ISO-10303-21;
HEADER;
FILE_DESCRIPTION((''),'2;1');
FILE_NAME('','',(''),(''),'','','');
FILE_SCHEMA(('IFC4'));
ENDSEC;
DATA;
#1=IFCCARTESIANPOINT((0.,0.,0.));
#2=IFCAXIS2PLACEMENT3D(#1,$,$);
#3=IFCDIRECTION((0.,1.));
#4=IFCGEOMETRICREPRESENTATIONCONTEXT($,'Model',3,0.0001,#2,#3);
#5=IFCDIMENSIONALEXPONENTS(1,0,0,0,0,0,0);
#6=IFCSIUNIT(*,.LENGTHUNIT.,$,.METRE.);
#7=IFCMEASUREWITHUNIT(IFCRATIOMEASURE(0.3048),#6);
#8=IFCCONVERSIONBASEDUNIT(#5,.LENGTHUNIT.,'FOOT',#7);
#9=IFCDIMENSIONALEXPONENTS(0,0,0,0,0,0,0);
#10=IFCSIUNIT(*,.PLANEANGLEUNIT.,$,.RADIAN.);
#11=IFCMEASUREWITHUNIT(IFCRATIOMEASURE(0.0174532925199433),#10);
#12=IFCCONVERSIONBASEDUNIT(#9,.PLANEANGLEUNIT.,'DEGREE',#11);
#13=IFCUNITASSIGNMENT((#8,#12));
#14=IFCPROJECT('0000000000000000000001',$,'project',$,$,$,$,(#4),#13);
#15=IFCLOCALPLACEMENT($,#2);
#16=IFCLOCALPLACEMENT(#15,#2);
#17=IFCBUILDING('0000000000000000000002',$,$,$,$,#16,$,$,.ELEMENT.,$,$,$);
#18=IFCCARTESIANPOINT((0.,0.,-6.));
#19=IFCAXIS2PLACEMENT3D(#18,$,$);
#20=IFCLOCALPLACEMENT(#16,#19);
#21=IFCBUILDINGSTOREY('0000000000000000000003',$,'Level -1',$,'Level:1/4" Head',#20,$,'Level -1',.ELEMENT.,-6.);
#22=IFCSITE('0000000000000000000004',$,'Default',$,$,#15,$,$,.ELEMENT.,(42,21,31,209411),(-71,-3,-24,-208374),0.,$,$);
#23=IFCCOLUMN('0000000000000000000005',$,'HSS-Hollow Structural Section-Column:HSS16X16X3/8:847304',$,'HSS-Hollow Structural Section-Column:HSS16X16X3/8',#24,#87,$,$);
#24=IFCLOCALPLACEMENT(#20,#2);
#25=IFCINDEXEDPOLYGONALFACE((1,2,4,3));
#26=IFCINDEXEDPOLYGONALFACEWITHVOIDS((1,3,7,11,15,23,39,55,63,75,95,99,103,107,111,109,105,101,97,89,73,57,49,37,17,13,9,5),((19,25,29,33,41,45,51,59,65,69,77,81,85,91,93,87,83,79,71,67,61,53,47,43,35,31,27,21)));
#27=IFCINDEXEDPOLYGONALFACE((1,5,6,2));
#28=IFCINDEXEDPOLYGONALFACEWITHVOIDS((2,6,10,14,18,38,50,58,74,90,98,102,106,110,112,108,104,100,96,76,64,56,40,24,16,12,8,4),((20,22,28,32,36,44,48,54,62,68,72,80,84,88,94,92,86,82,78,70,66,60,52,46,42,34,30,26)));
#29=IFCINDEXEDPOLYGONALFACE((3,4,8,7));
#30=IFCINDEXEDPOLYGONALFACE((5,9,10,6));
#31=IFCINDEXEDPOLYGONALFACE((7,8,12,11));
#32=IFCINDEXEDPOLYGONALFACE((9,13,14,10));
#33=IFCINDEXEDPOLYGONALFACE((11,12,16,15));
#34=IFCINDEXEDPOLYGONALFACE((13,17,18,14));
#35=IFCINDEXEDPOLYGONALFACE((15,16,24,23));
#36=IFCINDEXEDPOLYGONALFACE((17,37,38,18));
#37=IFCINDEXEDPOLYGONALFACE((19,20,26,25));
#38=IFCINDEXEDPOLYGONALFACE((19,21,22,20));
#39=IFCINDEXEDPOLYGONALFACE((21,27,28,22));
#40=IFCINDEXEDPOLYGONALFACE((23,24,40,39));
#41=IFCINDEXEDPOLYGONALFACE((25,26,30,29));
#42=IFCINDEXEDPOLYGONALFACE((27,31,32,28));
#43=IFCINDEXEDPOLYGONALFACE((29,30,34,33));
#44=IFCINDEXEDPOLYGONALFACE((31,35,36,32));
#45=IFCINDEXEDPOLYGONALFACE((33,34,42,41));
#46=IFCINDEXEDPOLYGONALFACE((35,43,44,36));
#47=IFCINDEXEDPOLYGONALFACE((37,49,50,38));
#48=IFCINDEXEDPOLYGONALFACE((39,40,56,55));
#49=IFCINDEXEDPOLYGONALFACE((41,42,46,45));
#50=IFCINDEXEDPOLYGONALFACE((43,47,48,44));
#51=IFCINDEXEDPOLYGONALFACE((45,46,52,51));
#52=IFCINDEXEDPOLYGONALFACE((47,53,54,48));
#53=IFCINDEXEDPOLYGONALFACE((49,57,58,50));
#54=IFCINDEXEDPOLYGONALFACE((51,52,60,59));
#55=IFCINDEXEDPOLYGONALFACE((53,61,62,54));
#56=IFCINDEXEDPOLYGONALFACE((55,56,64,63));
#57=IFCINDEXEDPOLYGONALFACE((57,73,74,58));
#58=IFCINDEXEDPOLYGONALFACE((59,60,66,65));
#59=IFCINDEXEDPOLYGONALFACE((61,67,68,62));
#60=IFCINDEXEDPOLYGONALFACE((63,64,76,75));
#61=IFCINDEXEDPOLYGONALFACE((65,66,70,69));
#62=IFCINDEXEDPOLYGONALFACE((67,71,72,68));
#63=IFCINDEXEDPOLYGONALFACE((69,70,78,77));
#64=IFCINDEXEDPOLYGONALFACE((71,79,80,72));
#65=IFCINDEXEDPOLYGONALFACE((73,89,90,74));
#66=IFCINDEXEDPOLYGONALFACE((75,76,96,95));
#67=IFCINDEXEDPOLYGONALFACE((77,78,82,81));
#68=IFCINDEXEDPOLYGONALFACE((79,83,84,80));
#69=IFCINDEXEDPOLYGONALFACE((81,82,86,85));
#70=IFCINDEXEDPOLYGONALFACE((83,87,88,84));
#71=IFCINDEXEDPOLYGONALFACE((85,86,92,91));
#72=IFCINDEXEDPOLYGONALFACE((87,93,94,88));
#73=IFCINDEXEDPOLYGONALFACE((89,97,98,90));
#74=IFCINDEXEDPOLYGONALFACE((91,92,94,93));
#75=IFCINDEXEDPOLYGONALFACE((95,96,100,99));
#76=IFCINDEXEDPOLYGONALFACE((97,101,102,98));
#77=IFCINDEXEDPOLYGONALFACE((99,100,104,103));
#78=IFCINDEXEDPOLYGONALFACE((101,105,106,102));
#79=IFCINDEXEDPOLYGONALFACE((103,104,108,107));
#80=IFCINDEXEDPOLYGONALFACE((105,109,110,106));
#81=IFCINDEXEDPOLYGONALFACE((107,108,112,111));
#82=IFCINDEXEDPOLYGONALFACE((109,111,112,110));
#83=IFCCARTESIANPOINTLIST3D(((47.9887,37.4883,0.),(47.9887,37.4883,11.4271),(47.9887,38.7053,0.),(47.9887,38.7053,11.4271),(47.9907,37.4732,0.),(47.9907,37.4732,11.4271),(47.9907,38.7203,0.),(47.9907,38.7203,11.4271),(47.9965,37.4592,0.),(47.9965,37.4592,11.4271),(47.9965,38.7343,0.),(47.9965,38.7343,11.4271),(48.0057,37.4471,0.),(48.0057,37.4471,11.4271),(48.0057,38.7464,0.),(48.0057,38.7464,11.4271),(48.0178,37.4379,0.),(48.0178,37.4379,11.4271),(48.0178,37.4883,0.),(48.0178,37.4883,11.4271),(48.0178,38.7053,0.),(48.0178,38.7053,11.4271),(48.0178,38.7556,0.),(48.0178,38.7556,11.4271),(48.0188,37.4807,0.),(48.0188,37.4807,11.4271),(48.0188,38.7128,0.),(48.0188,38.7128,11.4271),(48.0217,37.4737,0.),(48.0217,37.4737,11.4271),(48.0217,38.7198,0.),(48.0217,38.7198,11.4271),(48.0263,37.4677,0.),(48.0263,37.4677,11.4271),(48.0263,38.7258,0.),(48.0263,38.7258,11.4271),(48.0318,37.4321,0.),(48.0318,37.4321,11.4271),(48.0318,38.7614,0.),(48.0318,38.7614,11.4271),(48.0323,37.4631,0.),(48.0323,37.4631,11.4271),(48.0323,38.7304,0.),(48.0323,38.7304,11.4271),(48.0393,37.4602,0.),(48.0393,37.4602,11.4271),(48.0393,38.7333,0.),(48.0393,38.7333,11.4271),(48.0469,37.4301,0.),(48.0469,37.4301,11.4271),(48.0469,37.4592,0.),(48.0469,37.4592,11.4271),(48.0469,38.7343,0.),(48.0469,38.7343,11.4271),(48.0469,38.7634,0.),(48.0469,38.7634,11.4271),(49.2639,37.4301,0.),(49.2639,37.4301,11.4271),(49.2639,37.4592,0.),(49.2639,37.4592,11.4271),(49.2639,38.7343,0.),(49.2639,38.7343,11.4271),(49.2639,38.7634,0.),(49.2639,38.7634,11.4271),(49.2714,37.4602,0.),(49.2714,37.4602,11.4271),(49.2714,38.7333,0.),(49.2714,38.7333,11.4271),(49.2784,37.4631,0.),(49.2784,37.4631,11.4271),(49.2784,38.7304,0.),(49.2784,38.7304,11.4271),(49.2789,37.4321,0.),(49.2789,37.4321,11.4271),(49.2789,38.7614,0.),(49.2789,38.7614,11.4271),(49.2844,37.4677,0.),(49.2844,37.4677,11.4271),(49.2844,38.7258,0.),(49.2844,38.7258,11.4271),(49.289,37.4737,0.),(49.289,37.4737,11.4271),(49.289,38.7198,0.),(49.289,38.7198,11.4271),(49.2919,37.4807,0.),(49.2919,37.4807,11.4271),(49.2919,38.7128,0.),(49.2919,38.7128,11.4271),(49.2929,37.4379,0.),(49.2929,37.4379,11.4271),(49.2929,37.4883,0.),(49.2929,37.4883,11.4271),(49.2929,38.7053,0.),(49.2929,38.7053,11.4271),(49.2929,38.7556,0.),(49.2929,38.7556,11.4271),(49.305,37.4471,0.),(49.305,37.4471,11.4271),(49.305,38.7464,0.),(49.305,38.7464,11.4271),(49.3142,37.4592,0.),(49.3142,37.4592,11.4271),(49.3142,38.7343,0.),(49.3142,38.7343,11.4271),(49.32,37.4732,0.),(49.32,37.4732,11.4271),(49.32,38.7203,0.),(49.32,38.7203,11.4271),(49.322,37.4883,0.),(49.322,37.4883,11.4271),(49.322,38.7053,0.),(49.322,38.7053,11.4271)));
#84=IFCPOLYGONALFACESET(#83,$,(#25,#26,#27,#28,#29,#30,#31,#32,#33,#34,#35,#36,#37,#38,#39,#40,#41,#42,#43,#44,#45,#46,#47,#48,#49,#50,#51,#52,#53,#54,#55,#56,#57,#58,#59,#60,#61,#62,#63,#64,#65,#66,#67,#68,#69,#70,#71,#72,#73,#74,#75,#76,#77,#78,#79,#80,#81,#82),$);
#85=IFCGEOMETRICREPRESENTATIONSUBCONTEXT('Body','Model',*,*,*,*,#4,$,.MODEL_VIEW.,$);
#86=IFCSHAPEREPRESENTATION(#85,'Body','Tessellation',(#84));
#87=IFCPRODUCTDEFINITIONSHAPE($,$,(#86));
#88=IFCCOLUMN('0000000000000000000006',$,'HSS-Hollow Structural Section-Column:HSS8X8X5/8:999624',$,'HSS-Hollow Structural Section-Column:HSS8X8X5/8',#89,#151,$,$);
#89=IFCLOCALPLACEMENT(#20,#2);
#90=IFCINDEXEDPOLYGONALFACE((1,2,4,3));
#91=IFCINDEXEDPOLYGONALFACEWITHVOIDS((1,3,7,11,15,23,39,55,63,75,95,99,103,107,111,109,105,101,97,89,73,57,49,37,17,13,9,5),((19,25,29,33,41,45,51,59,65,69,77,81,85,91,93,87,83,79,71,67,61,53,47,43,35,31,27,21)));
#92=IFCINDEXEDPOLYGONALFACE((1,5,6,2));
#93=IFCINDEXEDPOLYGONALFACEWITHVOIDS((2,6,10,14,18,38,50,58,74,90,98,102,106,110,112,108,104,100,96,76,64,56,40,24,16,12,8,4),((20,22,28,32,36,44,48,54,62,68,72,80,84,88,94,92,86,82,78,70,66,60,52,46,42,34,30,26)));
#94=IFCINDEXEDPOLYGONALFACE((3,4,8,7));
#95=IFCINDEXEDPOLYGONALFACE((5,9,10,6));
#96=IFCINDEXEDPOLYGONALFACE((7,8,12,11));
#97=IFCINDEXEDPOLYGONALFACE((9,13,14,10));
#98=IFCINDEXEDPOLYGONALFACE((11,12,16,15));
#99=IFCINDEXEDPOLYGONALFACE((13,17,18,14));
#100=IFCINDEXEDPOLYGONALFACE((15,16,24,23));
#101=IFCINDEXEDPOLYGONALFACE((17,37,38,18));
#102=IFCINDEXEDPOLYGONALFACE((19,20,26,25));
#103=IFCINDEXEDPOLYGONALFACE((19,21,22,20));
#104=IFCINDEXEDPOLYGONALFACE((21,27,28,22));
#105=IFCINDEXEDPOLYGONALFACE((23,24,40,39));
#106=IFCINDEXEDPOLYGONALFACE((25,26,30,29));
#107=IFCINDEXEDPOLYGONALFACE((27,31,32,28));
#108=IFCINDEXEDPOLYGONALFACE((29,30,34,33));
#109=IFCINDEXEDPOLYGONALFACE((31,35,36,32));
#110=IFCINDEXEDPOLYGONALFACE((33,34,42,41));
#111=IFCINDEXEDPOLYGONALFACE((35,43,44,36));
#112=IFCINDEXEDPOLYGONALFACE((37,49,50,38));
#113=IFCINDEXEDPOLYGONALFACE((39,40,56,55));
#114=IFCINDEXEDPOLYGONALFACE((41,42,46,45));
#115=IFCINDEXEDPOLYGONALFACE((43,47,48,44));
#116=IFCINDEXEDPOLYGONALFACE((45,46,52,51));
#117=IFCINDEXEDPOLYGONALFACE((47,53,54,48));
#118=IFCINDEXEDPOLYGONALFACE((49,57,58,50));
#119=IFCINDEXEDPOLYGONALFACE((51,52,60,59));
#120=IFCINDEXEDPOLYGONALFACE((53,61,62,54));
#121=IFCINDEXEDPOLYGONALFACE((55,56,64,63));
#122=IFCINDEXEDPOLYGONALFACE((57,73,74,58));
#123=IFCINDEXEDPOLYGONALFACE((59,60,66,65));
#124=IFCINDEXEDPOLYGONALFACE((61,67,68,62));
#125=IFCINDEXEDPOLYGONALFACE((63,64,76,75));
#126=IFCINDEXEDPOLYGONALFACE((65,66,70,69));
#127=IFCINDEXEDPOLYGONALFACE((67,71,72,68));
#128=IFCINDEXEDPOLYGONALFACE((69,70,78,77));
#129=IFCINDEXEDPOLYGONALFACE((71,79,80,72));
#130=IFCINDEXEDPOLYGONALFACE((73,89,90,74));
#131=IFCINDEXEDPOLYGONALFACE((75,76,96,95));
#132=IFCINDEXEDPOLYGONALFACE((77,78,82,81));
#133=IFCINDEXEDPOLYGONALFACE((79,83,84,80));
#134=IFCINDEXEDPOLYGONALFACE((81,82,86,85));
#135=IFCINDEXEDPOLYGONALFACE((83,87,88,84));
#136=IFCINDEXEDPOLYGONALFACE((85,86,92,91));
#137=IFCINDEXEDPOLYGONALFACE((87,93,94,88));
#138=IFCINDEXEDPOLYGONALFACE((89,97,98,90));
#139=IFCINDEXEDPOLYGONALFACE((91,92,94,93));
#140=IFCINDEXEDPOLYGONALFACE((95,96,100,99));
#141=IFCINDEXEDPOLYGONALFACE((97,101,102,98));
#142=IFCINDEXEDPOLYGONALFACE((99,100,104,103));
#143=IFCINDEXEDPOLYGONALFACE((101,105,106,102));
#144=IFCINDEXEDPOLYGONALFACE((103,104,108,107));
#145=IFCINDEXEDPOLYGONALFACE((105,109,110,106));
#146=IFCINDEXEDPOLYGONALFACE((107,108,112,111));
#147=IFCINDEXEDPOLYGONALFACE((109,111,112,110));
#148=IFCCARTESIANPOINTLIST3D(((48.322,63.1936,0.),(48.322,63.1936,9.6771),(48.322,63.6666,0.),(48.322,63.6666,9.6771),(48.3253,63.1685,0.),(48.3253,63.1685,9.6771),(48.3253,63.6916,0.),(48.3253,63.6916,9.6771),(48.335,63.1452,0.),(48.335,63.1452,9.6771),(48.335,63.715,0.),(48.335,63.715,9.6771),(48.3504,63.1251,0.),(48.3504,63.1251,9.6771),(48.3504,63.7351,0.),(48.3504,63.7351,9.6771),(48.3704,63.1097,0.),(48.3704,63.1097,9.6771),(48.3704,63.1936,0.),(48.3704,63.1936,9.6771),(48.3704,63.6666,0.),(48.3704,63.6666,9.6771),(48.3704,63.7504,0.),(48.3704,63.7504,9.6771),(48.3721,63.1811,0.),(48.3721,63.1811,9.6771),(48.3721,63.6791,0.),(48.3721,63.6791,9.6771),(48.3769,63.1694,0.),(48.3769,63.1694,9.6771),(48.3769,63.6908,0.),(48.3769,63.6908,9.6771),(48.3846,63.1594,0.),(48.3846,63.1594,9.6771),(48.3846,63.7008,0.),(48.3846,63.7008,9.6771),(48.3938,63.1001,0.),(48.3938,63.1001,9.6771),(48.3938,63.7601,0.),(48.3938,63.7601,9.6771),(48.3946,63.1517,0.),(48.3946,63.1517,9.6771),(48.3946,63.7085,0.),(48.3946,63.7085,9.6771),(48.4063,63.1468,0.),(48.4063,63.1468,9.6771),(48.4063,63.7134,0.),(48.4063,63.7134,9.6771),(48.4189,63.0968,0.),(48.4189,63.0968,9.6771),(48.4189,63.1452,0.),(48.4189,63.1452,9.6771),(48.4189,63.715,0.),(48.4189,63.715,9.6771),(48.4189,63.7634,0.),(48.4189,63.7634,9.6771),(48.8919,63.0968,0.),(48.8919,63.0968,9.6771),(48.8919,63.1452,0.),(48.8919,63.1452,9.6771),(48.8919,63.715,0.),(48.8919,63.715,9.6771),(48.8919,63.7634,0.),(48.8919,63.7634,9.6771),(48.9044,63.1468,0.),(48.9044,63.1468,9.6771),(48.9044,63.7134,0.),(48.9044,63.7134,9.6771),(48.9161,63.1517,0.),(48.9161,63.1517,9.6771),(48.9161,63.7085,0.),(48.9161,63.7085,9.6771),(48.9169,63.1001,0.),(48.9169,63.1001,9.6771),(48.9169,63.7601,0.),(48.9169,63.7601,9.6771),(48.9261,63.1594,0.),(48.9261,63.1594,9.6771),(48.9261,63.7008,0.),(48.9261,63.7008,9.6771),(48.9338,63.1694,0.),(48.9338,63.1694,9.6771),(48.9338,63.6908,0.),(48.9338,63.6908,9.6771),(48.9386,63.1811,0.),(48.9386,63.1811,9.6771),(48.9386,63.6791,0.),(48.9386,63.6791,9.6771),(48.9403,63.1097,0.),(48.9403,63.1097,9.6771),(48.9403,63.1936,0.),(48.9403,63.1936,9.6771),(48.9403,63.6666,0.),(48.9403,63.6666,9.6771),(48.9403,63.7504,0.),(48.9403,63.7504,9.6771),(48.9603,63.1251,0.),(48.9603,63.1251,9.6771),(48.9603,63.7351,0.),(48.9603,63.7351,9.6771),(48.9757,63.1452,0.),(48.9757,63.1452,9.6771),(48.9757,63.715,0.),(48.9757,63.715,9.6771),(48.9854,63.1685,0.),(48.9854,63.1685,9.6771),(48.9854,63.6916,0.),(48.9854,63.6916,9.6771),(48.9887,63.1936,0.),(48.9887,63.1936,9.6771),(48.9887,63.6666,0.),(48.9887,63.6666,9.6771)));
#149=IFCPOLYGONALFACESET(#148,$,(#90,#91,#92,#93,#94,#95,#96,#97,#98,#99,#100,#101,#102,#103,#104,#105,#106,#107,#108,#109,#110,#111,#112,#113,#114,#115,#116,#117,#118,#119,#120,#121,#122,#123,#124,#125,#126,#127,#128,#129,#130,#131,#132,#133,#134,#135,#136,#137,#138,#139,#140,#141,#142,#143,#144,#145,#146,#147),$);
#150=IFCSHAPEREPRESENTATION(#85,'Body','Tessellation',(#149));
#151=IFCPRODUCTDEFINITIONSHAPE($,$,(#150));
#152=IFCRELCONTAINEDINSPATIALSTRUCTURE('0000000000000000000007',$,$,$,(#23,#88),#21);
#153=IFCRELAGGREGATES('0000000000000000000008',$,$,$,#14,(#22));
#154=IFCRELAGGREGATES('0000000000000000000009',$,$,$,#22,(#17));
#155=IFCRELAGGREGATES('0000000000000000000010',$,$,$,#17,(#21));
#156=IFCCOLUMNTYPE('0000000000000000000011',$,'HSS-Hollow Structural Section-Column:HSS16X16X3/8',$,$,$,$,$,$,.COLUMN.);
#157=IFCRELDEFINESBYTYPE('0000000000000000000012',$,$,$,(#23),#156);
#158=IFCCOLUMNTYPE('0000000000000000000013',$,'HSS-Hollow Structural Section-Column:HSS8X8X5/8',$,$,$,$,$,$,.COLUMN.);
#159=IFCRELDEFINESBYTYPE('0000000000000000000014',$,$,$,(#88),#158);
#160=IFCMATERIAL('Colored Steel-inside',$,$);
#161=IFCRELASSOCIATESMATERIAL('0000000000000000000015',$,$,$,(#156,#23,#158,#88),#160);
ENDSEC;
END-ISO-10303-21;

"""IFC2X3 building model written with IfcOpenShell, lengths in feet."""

from ifc_helpers import new_model, entity, si_unit, converted_unit, direction, frame, frame_2d, origin, place, context, subcontext, project, spatial, polyline, circle_curve, parameter, trimmed, segment, composite_curve, outline, extrude, source, transform, mapped, material, type_object, type_shapes, element, save


model = new_model("IFC2X3")

# Units and contexts
model_context = context("Model", 3, precision=0.0001, world=origin(), true_north=direction((0.0, 1.0)))
body_context = subcontext(model_context, "Body", "Model", "MODEL_VIEW")
ifc_project = project(units=[converted_unit("LENGTHUNIT", "FOOT", entity("IfcRatioMeasure", 0.3048), si_unit("LENGTHUNIT", "METRE"), dimensions=[1, 0, 0, 0, 0, 0, 0]), converted_unit("PLANEANGLEUNIT", "DEGREE", entity("IfcRatioMeasure", 0.0174532925199433), si_unit("PLANEANGLEUNIT", "RADIAN"), dimensions=[0, 0, 0, 0, 0, 0, 0])], contexts=[model_context])

# Site, building, storey
site_placement = place(None, origin())
site = spatial("IfcSite", under=ifc_project, at=site_placement, Name="Default", CompositionType="ELEMENT", RefLatitude=(42, 21, 31, 209411), RefLongitude=(-71, -3, -24, -208374), RefElevation=0.0)
building_placement = place(site_placement, origin())
building = spatial("IfcBuilding", under=site, at=building_placement, CompositionType="ELEMENT")
storey_placement = place(building_placement, frame((0.0, 0.0, -6.0)))
storey = spatial("IfcBuildingStorey", under=building, at=storey_placement, Name="Level -1", ObjectType="Level:1/4\" Head", LongName="Level -1", CompositionType="ELEMENT", Elevation=-6.0)

# Columns
ifc_material_1 = material(Name="Colored Steel-inside")
column_type_1 = type_object("IfcColumnType", Name="HSS-Hollow Structural Section-Column:HSS16X16X3/8", PredefinedType="COLUMN", material=ifc_material_1)
shared_shape_1 = source(origin(), body_context, "Body", "SweptSolid", [
    extrude(outline(composite_curve([segment(polyline([(-0.6085, -0.6667), (0.6085, -0.6667)]), True, "CONTINUOUS"), segment(trimmed(circle_curve(frame_2d((0.6085, -0.6085), x_axis=(-1.0, 0.0)), 0.0582), [parameter(90.0)], [parameter(180.0)], True, "PARAMETER"), True, "CONTINUOUS"), segment(polyline([(0.6667, -0.6085), (0.6667, 0.6085)]), True, "CONTINUOUS"), segment(trimmed(circle_curve(frame_2d((0.6085, 0.6085), x_axis=(-1.0, 0.0)), 0.0582), [parameter(180.0)], [parameter(270.0)], True, "PARAMETER"), True, "CONTINUOUS"), segment(polyline([(0.6085, 0.6667), (-0.6085, 0.6667)]), True, "CONTINUOUS"), segment(trimmed(circle_curve(frame_2d((-0.6085, 0.6085), x_axis=(-1.0, 0.0)), 0.0582), [parameter(270.0)], [parameter(360.0)], True, "PARAMETER"), True, "CONTINUOUS"), segment(polyline([(-0.6667, 0.6085), (-0.6667, -0.6085)]), True, "CONTINUOUS"), segment(trimmed(circle_curve(frame_2d((-0.6085, -0.6085), x_axis=(-1.0, 0.0)), 0.0582), [parameter(360.0)], [parameter(90.0)], True, "PARAMETER"), True, "CONTINUOUS")], self_intersect=False), holes=[composite_curve([segment(trimmed(circle_curve(frame_2d((-0.6085, -0.6085), x_axis=(-1.0, 0.0)), 0.0291), [parameter(0.0)], [parameter(90.0)], True, "PARAMETER"), False, "CONTINUOUS"), segment(polyline([(-0.6376, -0.6085), (-0.6376, 0.6085)]), True, "CONTINUOUS"), segment(trimmed(circle_curve(frame_2d((-0.6085, 0.6085), x_axis=(-1.0, 0.0)), 0.0291), [parameter(270.0)], [parameter(360.0)], True, "PARAMETER"), False, "CONTINUOUS"), segment(polyline([(-0.6085, 0.6376), (0.6085, 0.6376)]), True, "CONTINUOUS"), segment(trimmed(circle_curve(frame_2d((0.6085, 0.6085), x_axis=(-1.0, 0.0)), 0.0291), [parameter(180.0)], [parameter(270.0)], True, "PARAMETER"), False, "CONTINUOUS"), segment(polyline([(0.6376, 0.6085), (0.6376, -0.6085)]), True, "CONTINUOUS"), segment(trimmed(circle_curve(frame_2d((0.6085, -0.6085), x_axis=(-1.0, 0.0)), 0.0291), [parameter(90.0)], [parameter(180.0)], True, "PARAMETER"), False, "CONTINUOUS"), segment(polyline([(0.6085, -0.6376), (-0.6085, -0.6376)]), True, "CONTINUOUS")], self_intersect=False)]), frame((0.0, 0.0, -6.0), z_axis=(0.0, 0.0, 1.0), x_axis=(-1.0, 0.0, 0.0)), (0.0, 0.0, 1.0), 11.4271),
])
type_shapes(column_type_1, [shared_shape_1])
column_1_placement = place(storey_placement, frame((48.6554, 38.0968, 6.0)))
element("IfcColumn", 1, at=column_1_placement, inside=storey, type_object=column_type_1, material=ifc_material_1, Name="HSS-Hollow Structural Section-Column:HSS16X16X3/8:847304", ObjectType="HSS-Hollow Structural Section-Column:HSS16X16X3/8", context=body_context, shape_type="MappedRepresentation", body=[
    mapped(shared_shape_1, transform((0.0, 0.0, 0.0), scale=1.0)),
])
column_type_2 = type_object("IfcColumnType", Name="HSS-Hollow Structural Section-Column:HSS8X8X5/8", PredefinedType="COLUMN", material=ifc_material_1)
shared_shape_2 = source(origin(), body_context, "Body", "SweptSolid", [
    extrude(outline(composite_curve([segment(polyline([(-0.2365, -0.3333), (0.2365, -0.3333)]), True, "CONTINUOUS"), segment(trimmed(circle_curve(frame_2d((0.2365, -0.2365), x_axis=(-1.0, 0.0)), 0.0968), [parameter(90.0)], [parameter(180.0)], True, "PARAMETER"), True, "CONTINUOUS"), segment(polyline([(0.3333, -0.2365), (0.3333, 0.2365)]), True, "CONTINUOUS"), segment(trimmed(circle_curve(frame_2d((0.2365, 0.2365), x_axis=(-1.0, 0.0)), 0.0968), [parameter(180.0)], [parameter(270.0)], True, "PARAMETER"), True, "CONTINUOUS"), segment(polyline([(0.2365, 0.3333), (-0.2365, 0.3333)]), True, "CONTINUOUS"), segment(trimmed(circle_curve(frame_2d((-0.2365, 0.2365), x_axis=(-1.0, 0.0)), 0.0968), [parameter(270.0)], [parameter(360.0)], True, "PARAMETER"), True, "CONTINUOUS"), segment(polyline([(-0.3333, 0.2365), (-0.3333, -0.2365)]), True, "CONTINUOUS"), segment(trimmed(circle_curve(frame_2d((-0.2365, -0.2365), x_axis=(-1.0, 0.0)), 0.0968), [parameter(360.0)], [parameter(90.0)], True, "PARAMETER"), True, "CONTINUOUS")], self_intersect=False), holes=[composite_curve([segment(trimmed(circle_curve(frame_2d((-0.2365, -0.2365), x_axis=(-1.0, 0.0)), 0.0484), [parameter(0.0)], [parameter(90.0)], True, "PARAMETER"), False, "CONTINUOUS"), segment(polyline([(-0.2849, -0.2365), (-0.2849, 0.2365)]), True, "CONTINUOUS"), segment(trimmed(circle_curve(frame_2d((-0.2365, 0.2365), x_axis=(-1.0, 0.0)), 0.0484), [parameter(270.0)], [parameter(360.0)], True, "PARAMETER"), False, "CONTINUOUS"), segment(polyline([(-0.2365, 0.2849), (0.2365, 0.2849)]), True, "CONTINUOUS"), segment(trimmed(circle_curve(frame_2d((0.2365, 0.2365), x_axis=(-1.0, 0.0)), 0.0484), [parameter(180.0)], [parameter(270.0)], True, "PARAMETER"), False, "CONTINUOUS"), segment(polyline([(0.2849, 0.2365), (0.2849, -0.2365)]), True, "CONTINUOUS"), segment(trimmed(circle_curve(frame_2d((0.2365, -0.2365), x_axis=(-1.0, 0.0)), 0.0484), [parameter(90.0)], [parameter(180.0)], True, "PARAMETER"), False, "CONTINUOUS"), segment(polyline([(0.2365, -0.2849), (-0.2365, -0.2849)]), True, "CONTINUOUS")], self_intersect=False)]), frame((0.0, 0.0, -6.0), z_axis=(0.0, 0.0, 1.0), x_axis=(-1.0, 0.0, 0.0)), (0.0, 0.0, 1.0), 9.6771),
])
type_shapes(column_type_2, [shared_shape_2])
for number, where, z_axis, x_axis, name in (
    (2, (48.6554, 63.4301, 6.0), (0.0, 0.0, 1.0), (-1.0, 0.0, 0.0), "HSS-Hollow Structural Section-Column:HSS8X8X5/8:999624"),
):
    element("IfcColumn", number, at=place(storey_placement, frame(where, z_axis=z_axis, x_axis=x_axis)), inside=storey, type_object=column_type_2, material=ifc_material_1, Name=name, ObjectType="HSS-Hollow Structural Section-Column:HSS8X8X5/8", context=body_context, shape_type="MappedRepresentation", body=[
        mapped(shared_shape_2, transform((0.0, 0.0, 0.0), scale=1.0)),
    ])

save(model, "model.ifc")
